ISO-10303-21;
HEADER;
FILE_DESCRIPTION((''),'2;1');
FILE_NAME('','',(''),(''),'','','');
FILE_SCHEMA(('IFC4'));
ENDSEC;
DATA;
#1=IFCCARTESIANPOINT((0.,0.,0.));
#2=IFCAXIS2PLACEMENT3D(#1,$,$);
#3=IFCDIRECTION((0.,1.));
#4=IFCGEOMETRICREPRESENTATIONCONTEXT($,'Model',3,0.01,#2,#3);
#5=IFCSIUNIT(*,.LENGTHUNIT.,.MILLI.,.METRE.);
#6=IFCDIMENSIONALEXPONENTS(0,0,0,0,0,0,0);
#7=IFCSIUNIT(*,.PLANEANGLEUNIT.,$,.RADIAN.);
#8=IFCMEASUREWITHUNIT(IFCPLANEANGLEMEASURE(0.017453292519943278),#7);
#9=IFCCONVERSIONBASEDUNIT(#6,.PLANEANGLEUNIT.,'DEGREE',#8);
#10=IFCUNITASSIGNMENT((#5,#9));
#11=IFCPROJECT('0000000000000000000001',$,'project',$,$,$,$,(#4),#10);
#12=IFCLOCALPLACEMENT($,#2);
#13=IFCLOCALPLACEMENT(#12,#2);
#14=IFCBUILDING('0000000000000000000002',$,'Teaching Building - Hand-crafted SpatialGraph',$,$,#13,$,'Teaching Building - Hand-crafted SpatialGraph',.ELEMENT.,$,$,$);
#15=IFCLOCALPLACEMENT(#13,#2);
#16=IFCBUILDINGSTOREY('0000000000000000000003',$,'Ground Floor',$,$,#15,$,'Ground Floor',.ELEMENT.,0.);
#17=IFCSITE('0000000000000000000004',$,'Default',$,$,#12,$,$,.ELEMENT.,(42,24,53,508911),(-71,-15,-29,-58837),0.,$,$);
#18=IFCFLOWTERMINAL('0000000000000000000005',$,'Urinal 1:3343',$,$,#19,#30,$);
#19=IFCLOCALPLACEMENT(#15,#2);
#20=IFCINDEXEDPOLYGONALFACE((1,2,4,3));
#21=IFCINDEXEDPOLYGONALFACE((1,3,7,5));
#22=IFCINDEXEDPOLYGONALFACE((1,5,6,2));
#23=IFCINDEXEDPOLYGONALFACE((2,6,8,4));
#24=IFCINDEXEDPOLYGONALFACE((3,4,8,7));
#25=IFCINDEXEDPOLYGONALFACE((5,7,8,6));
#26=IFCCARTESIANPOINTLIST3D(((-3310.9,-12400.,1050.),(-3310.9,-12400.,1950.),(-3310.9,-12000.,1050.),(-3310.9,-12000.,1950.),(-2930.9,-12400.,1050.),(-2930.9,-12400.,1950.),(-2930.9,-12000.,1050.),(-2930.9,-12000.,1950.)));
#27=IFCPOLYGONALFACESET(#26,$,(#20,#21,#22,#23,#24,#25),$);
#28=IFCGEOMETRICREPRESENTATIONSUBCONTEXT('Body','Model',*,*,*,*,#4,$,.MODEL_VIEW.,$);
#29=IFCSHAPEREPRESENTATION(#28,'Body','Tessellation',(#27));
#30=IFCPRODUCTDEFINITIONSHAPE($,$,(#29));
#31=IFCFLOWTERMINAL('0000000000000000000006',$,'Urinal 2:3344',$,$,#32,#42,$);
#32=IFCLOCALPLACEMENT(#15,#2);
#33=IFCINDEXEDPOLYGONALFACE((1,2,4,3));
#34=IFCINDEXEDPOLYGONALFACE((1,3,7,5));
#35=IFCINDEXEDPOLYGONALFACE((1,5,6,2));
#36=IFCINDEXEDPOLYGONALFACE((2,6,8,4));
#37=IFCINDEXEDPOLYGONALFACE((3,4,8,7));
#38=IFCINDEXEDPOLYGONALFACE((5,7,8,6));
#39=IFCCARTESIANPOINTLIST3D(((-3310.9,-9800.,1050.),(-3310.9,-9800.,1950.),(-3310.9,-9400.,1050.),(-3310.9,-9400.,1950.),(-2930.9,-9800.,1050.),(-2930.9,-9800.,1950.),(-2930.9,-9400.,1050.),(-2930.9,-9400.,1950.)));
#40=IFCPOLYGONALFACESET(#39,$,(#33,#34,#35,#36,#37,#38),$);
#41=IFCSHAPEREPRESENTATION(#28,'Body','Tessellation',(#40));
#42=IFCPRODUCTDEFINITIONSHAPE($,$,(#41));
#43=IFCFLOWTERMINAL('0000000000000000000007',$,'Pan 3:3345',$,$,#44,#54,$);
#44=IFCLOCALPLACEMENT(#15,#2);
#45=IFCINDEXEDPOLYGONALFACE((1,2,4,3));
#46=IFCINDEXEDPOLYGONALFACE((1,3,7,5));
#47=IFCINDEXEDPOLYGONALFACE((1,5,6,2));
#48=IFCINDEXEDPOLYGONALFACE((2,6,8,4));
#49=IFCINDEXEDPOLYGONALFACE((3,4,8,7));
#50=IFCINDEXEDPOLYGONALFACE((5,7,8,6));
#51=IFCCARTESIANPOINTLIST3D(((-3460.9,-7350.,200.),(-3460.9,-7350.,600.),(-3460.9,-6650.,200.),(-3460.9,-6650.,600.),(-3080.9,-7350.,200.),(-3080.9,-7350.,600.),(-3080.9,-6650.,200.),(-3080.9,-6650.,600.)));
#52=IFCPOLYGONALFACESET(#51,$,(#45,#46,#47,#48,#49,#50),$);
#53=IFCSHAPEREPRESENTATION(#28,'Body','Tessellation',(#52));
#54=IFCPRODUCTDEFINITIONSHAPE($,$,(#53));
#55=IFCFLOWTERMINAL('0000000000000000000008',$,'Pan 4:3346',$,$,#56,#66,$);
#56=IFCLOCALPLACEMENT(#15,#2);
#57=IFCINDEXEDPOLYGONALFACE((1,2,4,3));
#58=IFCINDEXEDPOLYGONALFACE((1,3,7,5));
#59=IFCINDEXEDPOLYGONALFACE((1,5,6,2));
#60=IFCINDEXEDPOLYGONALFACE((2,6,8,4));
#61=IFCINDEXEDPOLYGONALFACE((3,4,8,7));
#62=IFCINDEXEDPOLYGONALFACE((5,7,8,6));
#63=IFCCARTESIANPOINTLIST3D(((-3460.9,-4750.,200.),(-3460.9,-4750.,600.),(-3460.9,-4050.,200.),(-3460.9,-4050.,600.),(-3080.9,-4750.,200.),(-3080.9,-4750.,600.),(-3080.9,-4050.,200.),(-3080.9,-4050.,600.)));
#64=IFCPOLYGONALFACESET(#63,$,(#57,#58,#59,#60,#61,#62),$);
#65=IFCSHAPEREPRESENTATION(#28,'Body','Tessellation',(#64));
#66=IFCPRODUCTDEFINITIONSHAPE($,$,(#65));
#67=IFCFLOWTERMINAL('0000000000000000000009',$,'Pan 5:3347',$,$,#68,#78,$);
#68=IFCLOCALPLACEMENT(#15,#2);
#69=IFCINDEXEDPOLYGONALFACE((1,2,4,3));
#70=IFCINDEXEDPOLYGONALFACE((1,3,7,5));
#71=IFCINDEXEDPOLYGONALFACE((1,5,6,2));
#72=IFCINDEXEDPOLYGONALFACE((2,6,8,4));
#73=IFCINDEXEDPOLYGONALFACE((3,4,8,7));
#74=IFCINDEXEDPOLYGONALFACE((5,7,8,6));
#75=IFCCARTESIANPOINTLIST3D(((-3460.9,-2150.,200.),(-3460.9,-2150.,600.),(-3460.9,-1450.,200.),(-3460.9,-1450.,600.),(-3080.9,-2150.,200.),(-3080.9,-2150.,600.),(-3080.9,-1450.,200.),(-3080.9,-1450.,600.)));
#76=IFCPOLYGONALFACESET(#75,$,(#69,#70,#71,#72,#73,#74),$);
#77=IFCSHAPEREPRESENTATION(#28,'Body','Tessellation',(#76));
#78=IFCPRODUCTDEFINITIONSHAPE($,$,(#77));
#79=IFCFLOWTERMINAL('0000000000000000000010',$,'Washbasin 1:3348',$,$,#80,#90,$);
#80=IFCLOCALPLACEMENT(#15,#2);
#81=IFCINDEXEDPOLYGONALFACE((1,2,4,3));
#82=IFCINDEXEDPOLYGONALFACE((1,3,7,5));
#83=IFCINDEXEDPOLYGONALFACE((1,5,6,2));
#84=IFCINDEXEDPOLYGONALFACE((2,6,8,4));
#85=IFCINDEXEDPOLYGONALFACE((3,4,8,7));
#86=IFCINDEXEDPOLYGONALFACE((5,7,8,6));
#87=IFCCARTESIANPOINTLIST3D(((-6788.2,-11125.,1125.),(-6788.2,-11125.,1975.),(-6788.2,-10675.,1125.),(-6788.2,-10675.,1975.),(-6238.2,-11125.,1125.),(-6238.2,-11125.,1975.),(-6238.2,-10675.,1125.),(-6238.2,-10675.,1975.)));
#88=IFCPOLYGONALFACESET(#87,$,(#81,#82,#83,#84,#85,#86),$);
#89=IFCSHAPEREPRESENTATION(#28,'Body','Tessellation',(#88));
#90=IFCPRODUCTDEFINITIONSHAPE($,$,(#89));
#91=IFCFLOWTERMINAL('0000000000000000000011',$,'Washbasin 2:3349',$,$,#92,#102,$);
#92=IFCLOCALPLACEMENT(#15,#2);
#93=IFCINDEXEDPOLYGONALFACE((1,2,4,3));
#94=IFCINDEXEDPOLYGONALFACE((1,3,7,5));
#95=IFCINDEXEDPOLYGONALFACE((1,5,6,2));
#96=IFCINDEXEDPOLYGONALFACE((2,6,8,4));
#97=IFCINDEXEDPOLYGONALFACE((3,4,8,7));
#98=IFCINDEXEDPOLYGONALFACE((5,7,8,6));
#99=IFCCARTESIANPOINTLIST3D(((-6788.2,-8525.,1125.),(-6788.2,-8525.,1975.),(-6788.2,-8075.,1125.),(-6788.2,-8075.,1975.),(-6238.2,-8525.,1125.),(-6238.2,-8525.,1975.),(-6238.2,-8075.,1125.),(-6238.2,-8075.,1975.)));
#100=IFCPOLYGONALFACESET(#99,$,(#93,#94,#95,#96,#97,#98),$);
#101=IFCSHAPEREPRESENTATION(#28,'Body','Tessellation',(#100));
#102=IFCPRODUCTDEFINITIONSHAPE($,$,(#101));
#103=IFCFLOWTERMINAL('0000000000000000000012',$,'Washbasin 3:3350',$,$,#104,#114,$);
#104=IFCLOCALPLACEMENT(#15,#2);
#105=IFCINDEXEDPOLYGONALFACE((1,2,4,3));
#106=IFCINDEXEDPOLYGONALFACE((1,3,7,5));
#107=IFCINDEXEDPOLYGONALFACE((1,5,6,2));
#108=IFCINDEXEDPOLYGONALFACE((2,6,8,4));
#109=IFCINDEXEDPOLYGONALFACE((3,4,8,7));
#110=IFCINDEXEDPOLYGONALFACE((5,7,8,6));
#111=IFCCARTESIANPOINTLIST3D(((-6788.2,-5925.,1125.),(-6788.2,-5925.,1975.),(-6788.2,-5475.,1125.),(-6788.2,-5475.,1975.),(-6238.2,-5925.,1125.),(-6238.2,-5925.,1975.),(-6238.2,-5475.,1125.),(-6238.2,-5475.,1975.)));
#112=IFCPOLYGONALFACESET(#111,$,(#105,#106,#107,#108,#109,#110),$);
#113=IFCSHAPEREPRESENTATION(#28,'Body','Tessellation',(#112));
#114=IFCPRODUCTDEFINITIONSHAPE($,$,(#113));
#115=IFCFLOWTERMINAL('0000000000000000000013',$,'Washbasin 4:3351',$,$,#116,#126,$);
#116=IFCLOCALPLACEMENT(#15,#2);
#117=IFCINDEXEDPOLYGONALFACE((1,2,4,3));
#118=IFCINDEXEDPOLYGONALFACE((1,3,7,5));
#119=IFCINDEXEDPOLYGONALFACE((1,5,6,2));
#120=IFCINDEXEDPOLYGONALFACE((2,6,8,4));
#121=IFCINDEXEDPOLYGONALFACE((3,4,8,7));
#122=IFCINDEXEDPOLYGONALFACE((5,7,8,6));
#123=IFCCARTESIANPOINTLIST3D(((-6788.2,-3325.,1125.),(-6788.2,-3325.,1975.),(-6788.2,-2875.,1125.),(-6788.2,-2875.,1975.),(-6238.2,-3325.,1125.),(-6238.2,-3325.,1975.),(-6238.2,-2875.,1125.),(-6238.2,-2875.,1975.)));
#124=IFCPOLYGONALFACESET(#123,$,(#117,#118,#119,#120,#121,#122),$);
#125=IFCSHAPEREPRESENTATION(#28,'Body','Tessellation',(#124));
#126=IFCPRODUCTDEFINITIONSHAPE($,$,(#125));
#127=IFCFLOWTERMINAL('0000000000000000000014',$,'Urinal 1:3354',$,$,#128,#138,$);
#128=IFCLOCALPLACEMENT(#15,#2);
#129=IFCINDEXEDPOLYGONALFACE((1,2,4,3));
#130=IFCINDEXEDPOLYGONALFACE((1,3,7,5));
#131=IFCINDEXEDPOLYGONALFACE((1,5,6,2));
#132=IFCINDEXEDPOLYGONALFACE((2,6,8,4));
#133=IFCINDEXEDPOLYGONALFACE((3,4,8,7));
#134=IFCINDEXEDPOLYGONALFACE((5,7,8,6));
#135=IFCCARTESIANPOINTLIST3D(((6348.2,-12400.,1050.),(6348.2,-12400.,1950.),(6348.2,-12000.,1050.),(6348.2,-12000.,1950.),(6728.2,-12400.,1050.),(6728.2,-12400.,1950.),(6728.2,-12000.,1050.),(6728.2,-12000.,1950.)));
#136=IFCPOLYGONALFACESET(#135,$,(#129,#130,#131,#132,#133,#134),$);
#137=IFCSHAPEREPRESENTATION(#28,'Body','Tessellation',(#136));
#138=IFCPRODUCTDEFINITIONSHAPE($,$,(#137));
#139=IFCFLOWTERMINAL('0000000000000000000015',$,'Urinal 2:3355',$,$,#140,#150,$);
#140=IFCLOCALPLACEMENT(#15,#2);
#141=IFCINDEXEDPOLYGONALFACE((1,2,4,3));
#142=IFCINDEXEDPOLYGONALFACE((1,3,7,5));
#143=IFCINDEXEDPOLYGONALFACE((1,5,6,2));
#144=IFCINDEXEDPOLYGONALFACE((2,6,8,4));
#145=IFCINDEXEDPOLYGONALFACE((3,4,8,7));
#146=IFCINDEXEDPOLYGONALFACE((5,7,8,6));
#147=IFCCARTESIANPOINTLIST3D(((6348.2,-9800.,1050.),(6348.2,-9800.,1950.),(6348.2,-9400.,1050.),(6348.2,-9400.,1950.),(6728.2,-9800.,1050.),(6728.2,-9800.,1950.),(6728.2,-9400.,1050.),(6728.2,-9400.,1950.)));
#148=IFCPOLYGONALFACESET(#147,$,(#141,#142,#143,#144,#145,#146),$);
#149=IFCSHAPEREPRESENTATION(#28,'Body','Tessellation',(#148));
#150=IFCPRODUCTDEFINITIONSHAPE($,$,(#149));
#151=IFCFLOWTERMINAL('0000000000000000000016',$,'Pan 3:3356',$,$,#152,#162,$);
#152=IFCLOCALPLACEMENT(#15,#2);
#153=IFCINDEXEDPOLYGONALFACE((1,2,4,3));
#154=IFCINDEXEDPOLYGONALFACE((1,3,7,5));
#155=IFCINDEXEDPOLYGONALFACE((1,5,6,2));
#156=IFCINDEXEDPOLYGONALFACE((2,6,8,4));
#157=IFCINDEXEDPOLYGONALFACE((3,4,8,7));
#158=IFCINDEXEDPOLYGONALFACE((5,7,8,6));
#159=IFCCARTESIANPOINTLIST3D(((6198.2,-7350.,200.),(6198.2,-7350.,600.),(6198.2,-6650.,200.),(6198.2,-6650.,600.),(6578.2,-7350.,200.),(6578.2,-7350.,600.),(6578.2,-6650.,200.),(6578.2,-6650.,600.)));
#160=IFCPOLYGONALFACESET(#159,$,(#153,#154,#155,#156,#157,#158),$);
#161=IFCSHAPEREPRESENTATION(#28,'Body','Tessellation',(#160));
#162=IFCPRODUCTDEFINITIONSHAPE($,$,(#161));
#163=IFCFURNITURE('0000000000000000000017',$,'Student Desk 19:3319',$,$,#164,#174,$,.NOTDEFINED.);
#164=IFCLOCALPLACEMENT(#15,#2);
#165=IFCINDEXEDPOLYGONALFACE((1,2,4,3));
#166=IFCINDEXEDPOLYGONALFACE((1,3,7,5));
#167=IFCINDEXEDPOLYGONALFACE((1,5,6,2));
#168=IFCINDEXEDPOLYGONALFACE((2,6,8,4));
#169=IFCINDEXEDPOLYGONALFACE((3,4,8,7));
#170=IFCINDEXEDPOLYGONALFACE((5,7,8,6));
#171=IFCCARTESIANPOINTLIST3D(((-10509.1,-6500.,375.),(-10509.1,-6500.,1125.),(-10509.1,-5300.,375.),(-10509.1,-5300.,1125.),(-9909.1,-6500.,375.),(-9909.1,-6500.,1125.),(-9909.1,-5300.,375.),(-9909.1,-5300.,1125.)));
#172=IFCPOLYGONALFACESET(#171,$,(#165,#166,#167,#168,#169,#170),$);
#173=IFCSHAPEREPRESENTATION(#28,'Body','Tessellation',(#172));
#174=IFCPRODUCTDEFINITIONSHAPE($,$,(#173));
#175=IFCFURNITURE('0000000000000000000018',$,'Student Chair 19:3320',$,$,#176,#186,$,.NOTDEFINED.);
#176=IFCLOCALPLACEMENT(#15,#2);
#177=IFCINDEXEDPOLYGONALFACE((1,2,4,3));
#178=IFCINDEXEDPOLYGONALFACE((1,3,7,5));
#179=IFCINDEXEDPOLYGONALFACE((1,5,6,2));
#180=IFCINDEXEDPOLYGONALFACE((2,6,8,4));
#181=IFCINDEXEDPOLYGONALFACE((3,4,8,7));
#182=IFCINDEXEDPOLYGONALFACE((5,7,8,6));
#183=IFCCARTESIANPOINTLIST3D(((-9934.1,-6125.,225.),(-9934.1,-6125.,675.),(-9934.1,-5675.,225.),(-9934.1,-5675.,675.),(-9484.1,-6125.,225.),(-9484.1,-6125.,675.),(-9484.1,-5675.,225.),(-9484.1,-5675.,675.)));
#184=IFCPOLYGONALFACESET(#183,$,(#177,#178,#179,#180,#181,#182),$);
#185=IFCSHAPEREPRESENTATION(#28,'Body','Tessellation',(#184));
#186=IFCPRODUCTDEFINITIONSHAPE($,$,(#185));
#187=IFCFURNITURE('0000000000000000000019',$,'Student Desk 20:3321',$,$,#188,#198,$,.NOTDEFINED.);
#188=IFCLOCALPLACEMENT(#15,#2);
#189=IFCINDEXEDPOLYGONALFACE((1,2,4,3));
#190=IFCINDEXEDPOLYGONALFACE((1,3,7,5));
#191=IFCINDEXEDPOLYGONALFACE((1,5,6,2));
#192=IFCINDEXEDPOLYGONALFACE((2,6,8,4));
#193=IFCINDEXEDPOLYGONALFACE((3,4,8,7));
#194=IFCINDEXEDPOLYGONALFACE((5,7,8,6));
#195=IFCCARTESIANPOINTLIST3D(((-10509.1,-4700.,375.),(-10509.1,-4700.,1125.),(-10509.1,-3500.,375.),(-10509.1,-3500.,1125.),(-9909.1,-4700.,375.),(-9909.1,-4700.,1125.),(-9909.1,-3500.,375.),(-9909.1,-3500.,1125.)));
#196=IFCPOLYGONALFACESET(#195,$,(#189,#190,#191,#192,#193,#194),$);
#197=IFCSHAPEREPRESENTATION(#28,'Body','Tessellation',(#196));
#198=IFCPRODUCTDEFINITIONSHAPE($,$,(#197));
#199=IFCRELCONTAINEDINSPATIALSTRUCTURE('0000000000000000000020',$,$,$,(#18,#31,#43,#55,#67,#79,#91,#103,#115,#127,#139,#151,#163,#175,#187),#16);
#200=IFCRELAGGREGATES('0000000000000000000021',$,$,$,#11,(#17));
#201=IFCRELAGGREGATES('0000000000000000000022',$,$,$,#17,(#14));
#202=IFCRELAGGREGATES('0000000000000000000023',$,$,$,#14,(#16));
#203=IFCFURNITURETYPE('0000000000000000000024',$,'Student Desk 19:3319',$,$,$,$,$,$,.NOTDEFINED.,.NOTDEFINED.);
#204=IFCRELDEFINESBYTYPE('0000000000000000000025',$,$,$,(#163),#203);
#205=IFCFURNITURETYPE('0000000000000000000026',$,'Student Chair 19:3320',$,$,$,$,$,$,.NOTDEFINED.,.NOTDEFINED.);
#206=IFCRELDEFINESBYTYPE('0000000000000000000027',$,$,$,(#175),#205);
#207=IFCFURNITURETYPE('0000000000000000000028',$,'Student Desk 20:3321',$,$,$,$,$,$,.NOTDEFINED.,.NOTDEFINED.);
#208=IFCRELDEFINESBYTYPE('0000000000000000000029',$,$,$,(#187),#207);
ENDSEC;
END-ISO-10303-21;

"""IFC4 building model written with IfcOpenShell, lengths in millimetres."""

from ifc_helpers import new_model, entity, si_unit, converted_unit, direction, frame, frame_2d, origin, origin_2d_with_axis, place, context, subcontext, project, spatial, rectangle, extrude, type_object, element, save


model = new_model("IFC4")

# Units and contexts
model_context = context("Model", 3, precision=0.01, world=origin(), true_north=direction((0.0, 1.0)))
body_context = subcontext(model_context, "Body", "Model", "MODEL_VIEW")
ifc_project = project(units=[si_unit("LENGTHUNIT", "METRE", prefix="MILLI"), converted_unit("PLANEANGLEUNIT", "DEGREE", entity("IfcPlaneAngleMeasure", 0.017453292519943278), si_unit("PLANEANGLEUNIT", "RADIAN"), dimensions=[0, 0, 0, 0, 0, 0, 0])], contexts=[model_context])

# Site, building, storey
site_placement = place(None, origin())
site = spatial("IfcSite", under=ifc_project, at=site_placement, Name="Default", CompositionType="ELEMENT", RefLatitude=(42, 24, 53, 508911), RefLongitude=(-71, -15, -29, -58837), RefElevation=0.0)
building_placement = place(site_placement, origin())
building = spatial("IfcBuilding", under=site, at=building_placement, Name="Teaching Building - Hand-crafted SpatialGraph", LongName="Teaching Building - Hand-crafted SpatialGraph", CompositionType="ELEMENT")
storey_placement = place(building_placement, origin())
storey = spatial("IfcBuildingStorey", under=building, at=storey_placement, Name="Ground Floor", LongName="Ground Floor", CompositionType="ELEMENT", Elevation=0.0)

# Flow terminals
flow_terminal_1_placement = place(storey_placement, origin())
element("IfcFlowTerminal", 1, at=flow_terminal_1_placement, inside=storey, Name="Urinal 1:3343", context=body_context, shape_type="SweptSolid", body=[
    extrude(rectangle(XDim=400.0, YDim=380.0, at=origin_2d_with_axis()), frame((-3120.9, -12200.0, 1050.0), z_axis=(0.0, 0.0, 1.0), x_axis=(0.0, 1.0, 0.0)), (0.0, 0.0, 1.0), 900.0),
])
flow_terminal_2_placement = place(storey_placement, origin())
element("IfcFlowTerminal", 2, at=flow_terminal_2_placement, inside=storey, Name="Urinal 2:3344", context=body_context, shape_type="SweptSolid", body=[
    extrude(rectangle(XDim=400.0, YDim=380.0, at=frame_2d((0.0, 0.0), x_axis=(1.0, 0.0))), frame((-3120.9, -9600.0, 1050.0), z_axis=(0.0, 0.0, 1.0), x_axis=(0.0, 1.0, 0.0)), (0.0, 0.0, 1.0), 900.0),
])
flow_terminal_3_placement = place(storey_placement, origin())
element("IfcFlowTerminal", 3, at=flow_terminal_3_placement, inside=storey, Name="Pan 3:3345", context=body_context, shape_type="SweptSolid", body=[
    extrude(rectangle(XDim=700.0, YDim=380.0, at=origin_2d_with_axis()), frame((-3270.9, -7000.0, 200.0), z_axis=(0.0, 0.0, 1.0), x_axis=(0.0, 1.0, 0.0)), (0.0, 0.0, 1.0), 400.0),
])
flow_terminal_4_placement = place(storey_placement, origin())
element("IfcFlowTerminal", 4, at=flow_terminal_4_placement, inside=storey, Name="Pan 4:3346", context=body_context, shape_type="SweptSolid", body=[
    extrude(rectangle(XDim=700.0, YDim=380.0, at=frame_2d((0.0, 0.0), x_axis=(1.0, 0.0))), frame((-3270.9, -4400.0, 200.0), z_axis=(0.0, 0.0, 1.0), x_axis=(0.0, 1.0, 0.0)), (0.0, 0.0, 1.0), 400.0),
])
flow_terminal_5_placement = place(storey_placement, origin())
element("IfcFlowTerminal", 5, at=flow_terminal_5_placement, inside=storey, Name="Pan 5:3347", context=body_context, shape_type="SweptSolid", body=[
    extrude(rectangle(XDim=700.0, YDim=380.0, at=origin_2d_with_axis()), frame((-3270.9, -1800.0, 200.0), z_axis=(0.0, 0.0, 1.0), x_axis=(0.0, 1.0, 0.0)), (0.0, 0.0, 1.0), 400.0),
])
flow_terminal_6_placement = place(storey_placement, origin())
element("IfcFlowTerminal", 6, at=flow_terminal_6_placement, inside=storey, Name="Washbasin 1:3348", context=body_context, shape_type="SweptSolid", body=[
    extrude(rectangle(XDim=450.0, YDim=550.0, at=origin_2d_with_axis()), frame((-6513.2, -10900.0, 1125.0), z_axis=(0.0, 0.0, 1.0), x_axis=(0.0, 1.0, 0.0)), (0.0, 0.0, 1.0), 850.0),
])
flow_terminal_7_placement = place(storey_placement, origin())
element("IfcFlowTerminal", 7, at=flow_terminal_7_placement, inside=storey, Name="Washbasin 2:3349", context=body_context, shape_type="SweptSolid", body=[
    extrude(rectangle(XDim=450.0, YDim=550.0, at=origin_2d_with_axis()), frame((-6513.2, -8300.0, 1125.0), z_axis=(0.0, 0.0, 1.0), x_axis=(0.0, 1.0, 0.0)), (0.0, 0.0, 1.0), 850.0),
])
flow_terminal_8_placement = place(storey_placement, origin())
element("IfcFlowTerminal", 8, at=flow_terminal_8_placement, inside=storey, Name="Washbasin 3:3350", context=body_context, shape_type="SweptSolid", body=[
    extrude(rectangle(XDim=450.0, YDim=550.0, at=origin_2d_with_axis()), frame((-6513.2, -5700.0, 1125.0), z_axis=(0.0, 0.0, 1.0), x_axis=(0.0, 1.0, 0.0)), (0.0, 0.0, 1.0), 850.0),
])
flow_terminal_9_placement = place(storey_placement, origin())
element("IfcFlowTerminal", 9, at=flow_terminal_9_placement, inside=storey, Name="Washbasin 4:3351", context=body_context, shape_type="SweptSolid", body=[
    extrude(rectangle(XDim=450.0, YDim=550.0, at=origin_2d_with_axis()), frame((-6513.2, -3100.0, 1125.0), z_axis=(0.0, 0.0, 1.0), x_axis=(0.0, 1.0, 0.0)), (0.0, 0.0, 1.0), 850.0),
])
flow_terminal_10_placement = place(storey_placement, origin())
element("IfcFlowTerminal", 10, at=flow_terminal_10_placement, inside=storey, Name="Urinal 1:3354", context=body_context, shape_type="SweptSolid", body=[
    extrude(rectangle(XDim=400.0, YDim=380.0, at=origin_2d_with_axis()), frame((6538.2, -12200.0, 1050.0), z_axis=(0.0, 0.0, 1.0), x_axis=(0.0, 1.0, 0.0)), (0.0, 0.0, 1.0), 900.0),
])
flow_terminal_11_placement = place(storey_placement, origin())
element("IfcFlowTerminal", 11, at=flow_terminal_11_placement, inside=storey, Name="Urinal 2:3355", context=body_context, shape_type="SweptSolid", body=[
    extrude(rectangle(XDim=400.0, YDim=380.0, at=frame_2d((0.0, 0.0), x_axis=(1.0, 0.0))), frame((6538.2, -9600.0, 1050.0), z_axis=(0.0, 0.0, 1.0), x_axis=(0.0, 1.0, 0.0)), (0.0, 0.0, 1.0), 900.0),
])
flow_terminal_12_placement = place(storey_placement, origin())
element("IfcFlowTerminal", 12, at=flow_terminal_12_placement, inside=storey, Name="Pan 3:3356", context=body_context, shape_type="SweptSolid", body=[
    extrude(rectangle(XDim=700.0, YDim=380.0, at=origin_2d_with_axis()), frame((6388.2, -7000.0, 200.0), z_axis=(0.0, 0.0, 1.0), x_axis=(0.0, 1.0, 0.0)), (0.0, 0.0, 1.0), 400.0),
])

# Furniture
furniture_type_1 = type_object("IfcFurnitureType", Name="Student Desk 19:3319", PredefinedType="NOTDEFINED")
furniture_1_placement = place(storey_placement, origin())
element("IfcFurniture", 13, at=furniture_1_placement, inside=storey, type_object=furniture_type_1, Name="Student Desk 19:3319", PredefinedType="NOTDEFINED", context=body_context, shape_type="SweptSolid", body=[
    extrude(rectangle(XDim=1200.0, YDim=600.0, at=origin_2d_with_axis()), frame((-10209.1, -5900.0, 375.0), z_axis=(0.0, 0.0, 1.0), x_axis=(0.0, 1.0, 0.0)), (0.0, 0.0, 1.0), 750.0),
])
furniture_type_2 = type_object("IfcFurnitureType", Name="Student Chair 19:3320", PredefinedType="NOTDEFINED")
furniture_2_placement = place(storey_placement, origin())
element("IfcFurniture", 14, at=furniture_2_placement, inside=storey, type_object=furniture_type_2, Name="Student Chair 19:3320", PredefinedType="NOTDEFINED", context=body_context, shape_type="SweptSolid", body=[
    extrude(rectangle(XDim=450.0, YDim=450.0, at=frame_2d((0.0, 0.0), x_axis=(1.0, 0.0))), frame((-9709.1, -5900.0, 225.0)), (0.0, 0.0, 1.0), 450.0),
])
furniture_type_3 = type_object("IfcFurnitureType", Name="Student Desk 20:3321", PredefinedType="NOTDEFINED")
furniture_3_placement = place(storey_placement, origin())
element("IfcFurniture", 15, at=furniture_3_placement, inside=storey, type_object=furniture_type_3, Name="Student Desk 20:3321", PredefinedType="NOTDEFINED", context=body_context, shape_type="SweptSolid", body=[
    extrude(rectangle(XDim=1200.0, YDim=600.0, at=origin_2d_with_axis()), frame((-10209.1, -4100.0, 375.0), z_axis=(0.0, 0.0, 1.0), x_axis=(0.0, 1.0, 0.0)), (0.0, 0.0, 1.0), 750.0),
])

save(model, "model.ifc")
